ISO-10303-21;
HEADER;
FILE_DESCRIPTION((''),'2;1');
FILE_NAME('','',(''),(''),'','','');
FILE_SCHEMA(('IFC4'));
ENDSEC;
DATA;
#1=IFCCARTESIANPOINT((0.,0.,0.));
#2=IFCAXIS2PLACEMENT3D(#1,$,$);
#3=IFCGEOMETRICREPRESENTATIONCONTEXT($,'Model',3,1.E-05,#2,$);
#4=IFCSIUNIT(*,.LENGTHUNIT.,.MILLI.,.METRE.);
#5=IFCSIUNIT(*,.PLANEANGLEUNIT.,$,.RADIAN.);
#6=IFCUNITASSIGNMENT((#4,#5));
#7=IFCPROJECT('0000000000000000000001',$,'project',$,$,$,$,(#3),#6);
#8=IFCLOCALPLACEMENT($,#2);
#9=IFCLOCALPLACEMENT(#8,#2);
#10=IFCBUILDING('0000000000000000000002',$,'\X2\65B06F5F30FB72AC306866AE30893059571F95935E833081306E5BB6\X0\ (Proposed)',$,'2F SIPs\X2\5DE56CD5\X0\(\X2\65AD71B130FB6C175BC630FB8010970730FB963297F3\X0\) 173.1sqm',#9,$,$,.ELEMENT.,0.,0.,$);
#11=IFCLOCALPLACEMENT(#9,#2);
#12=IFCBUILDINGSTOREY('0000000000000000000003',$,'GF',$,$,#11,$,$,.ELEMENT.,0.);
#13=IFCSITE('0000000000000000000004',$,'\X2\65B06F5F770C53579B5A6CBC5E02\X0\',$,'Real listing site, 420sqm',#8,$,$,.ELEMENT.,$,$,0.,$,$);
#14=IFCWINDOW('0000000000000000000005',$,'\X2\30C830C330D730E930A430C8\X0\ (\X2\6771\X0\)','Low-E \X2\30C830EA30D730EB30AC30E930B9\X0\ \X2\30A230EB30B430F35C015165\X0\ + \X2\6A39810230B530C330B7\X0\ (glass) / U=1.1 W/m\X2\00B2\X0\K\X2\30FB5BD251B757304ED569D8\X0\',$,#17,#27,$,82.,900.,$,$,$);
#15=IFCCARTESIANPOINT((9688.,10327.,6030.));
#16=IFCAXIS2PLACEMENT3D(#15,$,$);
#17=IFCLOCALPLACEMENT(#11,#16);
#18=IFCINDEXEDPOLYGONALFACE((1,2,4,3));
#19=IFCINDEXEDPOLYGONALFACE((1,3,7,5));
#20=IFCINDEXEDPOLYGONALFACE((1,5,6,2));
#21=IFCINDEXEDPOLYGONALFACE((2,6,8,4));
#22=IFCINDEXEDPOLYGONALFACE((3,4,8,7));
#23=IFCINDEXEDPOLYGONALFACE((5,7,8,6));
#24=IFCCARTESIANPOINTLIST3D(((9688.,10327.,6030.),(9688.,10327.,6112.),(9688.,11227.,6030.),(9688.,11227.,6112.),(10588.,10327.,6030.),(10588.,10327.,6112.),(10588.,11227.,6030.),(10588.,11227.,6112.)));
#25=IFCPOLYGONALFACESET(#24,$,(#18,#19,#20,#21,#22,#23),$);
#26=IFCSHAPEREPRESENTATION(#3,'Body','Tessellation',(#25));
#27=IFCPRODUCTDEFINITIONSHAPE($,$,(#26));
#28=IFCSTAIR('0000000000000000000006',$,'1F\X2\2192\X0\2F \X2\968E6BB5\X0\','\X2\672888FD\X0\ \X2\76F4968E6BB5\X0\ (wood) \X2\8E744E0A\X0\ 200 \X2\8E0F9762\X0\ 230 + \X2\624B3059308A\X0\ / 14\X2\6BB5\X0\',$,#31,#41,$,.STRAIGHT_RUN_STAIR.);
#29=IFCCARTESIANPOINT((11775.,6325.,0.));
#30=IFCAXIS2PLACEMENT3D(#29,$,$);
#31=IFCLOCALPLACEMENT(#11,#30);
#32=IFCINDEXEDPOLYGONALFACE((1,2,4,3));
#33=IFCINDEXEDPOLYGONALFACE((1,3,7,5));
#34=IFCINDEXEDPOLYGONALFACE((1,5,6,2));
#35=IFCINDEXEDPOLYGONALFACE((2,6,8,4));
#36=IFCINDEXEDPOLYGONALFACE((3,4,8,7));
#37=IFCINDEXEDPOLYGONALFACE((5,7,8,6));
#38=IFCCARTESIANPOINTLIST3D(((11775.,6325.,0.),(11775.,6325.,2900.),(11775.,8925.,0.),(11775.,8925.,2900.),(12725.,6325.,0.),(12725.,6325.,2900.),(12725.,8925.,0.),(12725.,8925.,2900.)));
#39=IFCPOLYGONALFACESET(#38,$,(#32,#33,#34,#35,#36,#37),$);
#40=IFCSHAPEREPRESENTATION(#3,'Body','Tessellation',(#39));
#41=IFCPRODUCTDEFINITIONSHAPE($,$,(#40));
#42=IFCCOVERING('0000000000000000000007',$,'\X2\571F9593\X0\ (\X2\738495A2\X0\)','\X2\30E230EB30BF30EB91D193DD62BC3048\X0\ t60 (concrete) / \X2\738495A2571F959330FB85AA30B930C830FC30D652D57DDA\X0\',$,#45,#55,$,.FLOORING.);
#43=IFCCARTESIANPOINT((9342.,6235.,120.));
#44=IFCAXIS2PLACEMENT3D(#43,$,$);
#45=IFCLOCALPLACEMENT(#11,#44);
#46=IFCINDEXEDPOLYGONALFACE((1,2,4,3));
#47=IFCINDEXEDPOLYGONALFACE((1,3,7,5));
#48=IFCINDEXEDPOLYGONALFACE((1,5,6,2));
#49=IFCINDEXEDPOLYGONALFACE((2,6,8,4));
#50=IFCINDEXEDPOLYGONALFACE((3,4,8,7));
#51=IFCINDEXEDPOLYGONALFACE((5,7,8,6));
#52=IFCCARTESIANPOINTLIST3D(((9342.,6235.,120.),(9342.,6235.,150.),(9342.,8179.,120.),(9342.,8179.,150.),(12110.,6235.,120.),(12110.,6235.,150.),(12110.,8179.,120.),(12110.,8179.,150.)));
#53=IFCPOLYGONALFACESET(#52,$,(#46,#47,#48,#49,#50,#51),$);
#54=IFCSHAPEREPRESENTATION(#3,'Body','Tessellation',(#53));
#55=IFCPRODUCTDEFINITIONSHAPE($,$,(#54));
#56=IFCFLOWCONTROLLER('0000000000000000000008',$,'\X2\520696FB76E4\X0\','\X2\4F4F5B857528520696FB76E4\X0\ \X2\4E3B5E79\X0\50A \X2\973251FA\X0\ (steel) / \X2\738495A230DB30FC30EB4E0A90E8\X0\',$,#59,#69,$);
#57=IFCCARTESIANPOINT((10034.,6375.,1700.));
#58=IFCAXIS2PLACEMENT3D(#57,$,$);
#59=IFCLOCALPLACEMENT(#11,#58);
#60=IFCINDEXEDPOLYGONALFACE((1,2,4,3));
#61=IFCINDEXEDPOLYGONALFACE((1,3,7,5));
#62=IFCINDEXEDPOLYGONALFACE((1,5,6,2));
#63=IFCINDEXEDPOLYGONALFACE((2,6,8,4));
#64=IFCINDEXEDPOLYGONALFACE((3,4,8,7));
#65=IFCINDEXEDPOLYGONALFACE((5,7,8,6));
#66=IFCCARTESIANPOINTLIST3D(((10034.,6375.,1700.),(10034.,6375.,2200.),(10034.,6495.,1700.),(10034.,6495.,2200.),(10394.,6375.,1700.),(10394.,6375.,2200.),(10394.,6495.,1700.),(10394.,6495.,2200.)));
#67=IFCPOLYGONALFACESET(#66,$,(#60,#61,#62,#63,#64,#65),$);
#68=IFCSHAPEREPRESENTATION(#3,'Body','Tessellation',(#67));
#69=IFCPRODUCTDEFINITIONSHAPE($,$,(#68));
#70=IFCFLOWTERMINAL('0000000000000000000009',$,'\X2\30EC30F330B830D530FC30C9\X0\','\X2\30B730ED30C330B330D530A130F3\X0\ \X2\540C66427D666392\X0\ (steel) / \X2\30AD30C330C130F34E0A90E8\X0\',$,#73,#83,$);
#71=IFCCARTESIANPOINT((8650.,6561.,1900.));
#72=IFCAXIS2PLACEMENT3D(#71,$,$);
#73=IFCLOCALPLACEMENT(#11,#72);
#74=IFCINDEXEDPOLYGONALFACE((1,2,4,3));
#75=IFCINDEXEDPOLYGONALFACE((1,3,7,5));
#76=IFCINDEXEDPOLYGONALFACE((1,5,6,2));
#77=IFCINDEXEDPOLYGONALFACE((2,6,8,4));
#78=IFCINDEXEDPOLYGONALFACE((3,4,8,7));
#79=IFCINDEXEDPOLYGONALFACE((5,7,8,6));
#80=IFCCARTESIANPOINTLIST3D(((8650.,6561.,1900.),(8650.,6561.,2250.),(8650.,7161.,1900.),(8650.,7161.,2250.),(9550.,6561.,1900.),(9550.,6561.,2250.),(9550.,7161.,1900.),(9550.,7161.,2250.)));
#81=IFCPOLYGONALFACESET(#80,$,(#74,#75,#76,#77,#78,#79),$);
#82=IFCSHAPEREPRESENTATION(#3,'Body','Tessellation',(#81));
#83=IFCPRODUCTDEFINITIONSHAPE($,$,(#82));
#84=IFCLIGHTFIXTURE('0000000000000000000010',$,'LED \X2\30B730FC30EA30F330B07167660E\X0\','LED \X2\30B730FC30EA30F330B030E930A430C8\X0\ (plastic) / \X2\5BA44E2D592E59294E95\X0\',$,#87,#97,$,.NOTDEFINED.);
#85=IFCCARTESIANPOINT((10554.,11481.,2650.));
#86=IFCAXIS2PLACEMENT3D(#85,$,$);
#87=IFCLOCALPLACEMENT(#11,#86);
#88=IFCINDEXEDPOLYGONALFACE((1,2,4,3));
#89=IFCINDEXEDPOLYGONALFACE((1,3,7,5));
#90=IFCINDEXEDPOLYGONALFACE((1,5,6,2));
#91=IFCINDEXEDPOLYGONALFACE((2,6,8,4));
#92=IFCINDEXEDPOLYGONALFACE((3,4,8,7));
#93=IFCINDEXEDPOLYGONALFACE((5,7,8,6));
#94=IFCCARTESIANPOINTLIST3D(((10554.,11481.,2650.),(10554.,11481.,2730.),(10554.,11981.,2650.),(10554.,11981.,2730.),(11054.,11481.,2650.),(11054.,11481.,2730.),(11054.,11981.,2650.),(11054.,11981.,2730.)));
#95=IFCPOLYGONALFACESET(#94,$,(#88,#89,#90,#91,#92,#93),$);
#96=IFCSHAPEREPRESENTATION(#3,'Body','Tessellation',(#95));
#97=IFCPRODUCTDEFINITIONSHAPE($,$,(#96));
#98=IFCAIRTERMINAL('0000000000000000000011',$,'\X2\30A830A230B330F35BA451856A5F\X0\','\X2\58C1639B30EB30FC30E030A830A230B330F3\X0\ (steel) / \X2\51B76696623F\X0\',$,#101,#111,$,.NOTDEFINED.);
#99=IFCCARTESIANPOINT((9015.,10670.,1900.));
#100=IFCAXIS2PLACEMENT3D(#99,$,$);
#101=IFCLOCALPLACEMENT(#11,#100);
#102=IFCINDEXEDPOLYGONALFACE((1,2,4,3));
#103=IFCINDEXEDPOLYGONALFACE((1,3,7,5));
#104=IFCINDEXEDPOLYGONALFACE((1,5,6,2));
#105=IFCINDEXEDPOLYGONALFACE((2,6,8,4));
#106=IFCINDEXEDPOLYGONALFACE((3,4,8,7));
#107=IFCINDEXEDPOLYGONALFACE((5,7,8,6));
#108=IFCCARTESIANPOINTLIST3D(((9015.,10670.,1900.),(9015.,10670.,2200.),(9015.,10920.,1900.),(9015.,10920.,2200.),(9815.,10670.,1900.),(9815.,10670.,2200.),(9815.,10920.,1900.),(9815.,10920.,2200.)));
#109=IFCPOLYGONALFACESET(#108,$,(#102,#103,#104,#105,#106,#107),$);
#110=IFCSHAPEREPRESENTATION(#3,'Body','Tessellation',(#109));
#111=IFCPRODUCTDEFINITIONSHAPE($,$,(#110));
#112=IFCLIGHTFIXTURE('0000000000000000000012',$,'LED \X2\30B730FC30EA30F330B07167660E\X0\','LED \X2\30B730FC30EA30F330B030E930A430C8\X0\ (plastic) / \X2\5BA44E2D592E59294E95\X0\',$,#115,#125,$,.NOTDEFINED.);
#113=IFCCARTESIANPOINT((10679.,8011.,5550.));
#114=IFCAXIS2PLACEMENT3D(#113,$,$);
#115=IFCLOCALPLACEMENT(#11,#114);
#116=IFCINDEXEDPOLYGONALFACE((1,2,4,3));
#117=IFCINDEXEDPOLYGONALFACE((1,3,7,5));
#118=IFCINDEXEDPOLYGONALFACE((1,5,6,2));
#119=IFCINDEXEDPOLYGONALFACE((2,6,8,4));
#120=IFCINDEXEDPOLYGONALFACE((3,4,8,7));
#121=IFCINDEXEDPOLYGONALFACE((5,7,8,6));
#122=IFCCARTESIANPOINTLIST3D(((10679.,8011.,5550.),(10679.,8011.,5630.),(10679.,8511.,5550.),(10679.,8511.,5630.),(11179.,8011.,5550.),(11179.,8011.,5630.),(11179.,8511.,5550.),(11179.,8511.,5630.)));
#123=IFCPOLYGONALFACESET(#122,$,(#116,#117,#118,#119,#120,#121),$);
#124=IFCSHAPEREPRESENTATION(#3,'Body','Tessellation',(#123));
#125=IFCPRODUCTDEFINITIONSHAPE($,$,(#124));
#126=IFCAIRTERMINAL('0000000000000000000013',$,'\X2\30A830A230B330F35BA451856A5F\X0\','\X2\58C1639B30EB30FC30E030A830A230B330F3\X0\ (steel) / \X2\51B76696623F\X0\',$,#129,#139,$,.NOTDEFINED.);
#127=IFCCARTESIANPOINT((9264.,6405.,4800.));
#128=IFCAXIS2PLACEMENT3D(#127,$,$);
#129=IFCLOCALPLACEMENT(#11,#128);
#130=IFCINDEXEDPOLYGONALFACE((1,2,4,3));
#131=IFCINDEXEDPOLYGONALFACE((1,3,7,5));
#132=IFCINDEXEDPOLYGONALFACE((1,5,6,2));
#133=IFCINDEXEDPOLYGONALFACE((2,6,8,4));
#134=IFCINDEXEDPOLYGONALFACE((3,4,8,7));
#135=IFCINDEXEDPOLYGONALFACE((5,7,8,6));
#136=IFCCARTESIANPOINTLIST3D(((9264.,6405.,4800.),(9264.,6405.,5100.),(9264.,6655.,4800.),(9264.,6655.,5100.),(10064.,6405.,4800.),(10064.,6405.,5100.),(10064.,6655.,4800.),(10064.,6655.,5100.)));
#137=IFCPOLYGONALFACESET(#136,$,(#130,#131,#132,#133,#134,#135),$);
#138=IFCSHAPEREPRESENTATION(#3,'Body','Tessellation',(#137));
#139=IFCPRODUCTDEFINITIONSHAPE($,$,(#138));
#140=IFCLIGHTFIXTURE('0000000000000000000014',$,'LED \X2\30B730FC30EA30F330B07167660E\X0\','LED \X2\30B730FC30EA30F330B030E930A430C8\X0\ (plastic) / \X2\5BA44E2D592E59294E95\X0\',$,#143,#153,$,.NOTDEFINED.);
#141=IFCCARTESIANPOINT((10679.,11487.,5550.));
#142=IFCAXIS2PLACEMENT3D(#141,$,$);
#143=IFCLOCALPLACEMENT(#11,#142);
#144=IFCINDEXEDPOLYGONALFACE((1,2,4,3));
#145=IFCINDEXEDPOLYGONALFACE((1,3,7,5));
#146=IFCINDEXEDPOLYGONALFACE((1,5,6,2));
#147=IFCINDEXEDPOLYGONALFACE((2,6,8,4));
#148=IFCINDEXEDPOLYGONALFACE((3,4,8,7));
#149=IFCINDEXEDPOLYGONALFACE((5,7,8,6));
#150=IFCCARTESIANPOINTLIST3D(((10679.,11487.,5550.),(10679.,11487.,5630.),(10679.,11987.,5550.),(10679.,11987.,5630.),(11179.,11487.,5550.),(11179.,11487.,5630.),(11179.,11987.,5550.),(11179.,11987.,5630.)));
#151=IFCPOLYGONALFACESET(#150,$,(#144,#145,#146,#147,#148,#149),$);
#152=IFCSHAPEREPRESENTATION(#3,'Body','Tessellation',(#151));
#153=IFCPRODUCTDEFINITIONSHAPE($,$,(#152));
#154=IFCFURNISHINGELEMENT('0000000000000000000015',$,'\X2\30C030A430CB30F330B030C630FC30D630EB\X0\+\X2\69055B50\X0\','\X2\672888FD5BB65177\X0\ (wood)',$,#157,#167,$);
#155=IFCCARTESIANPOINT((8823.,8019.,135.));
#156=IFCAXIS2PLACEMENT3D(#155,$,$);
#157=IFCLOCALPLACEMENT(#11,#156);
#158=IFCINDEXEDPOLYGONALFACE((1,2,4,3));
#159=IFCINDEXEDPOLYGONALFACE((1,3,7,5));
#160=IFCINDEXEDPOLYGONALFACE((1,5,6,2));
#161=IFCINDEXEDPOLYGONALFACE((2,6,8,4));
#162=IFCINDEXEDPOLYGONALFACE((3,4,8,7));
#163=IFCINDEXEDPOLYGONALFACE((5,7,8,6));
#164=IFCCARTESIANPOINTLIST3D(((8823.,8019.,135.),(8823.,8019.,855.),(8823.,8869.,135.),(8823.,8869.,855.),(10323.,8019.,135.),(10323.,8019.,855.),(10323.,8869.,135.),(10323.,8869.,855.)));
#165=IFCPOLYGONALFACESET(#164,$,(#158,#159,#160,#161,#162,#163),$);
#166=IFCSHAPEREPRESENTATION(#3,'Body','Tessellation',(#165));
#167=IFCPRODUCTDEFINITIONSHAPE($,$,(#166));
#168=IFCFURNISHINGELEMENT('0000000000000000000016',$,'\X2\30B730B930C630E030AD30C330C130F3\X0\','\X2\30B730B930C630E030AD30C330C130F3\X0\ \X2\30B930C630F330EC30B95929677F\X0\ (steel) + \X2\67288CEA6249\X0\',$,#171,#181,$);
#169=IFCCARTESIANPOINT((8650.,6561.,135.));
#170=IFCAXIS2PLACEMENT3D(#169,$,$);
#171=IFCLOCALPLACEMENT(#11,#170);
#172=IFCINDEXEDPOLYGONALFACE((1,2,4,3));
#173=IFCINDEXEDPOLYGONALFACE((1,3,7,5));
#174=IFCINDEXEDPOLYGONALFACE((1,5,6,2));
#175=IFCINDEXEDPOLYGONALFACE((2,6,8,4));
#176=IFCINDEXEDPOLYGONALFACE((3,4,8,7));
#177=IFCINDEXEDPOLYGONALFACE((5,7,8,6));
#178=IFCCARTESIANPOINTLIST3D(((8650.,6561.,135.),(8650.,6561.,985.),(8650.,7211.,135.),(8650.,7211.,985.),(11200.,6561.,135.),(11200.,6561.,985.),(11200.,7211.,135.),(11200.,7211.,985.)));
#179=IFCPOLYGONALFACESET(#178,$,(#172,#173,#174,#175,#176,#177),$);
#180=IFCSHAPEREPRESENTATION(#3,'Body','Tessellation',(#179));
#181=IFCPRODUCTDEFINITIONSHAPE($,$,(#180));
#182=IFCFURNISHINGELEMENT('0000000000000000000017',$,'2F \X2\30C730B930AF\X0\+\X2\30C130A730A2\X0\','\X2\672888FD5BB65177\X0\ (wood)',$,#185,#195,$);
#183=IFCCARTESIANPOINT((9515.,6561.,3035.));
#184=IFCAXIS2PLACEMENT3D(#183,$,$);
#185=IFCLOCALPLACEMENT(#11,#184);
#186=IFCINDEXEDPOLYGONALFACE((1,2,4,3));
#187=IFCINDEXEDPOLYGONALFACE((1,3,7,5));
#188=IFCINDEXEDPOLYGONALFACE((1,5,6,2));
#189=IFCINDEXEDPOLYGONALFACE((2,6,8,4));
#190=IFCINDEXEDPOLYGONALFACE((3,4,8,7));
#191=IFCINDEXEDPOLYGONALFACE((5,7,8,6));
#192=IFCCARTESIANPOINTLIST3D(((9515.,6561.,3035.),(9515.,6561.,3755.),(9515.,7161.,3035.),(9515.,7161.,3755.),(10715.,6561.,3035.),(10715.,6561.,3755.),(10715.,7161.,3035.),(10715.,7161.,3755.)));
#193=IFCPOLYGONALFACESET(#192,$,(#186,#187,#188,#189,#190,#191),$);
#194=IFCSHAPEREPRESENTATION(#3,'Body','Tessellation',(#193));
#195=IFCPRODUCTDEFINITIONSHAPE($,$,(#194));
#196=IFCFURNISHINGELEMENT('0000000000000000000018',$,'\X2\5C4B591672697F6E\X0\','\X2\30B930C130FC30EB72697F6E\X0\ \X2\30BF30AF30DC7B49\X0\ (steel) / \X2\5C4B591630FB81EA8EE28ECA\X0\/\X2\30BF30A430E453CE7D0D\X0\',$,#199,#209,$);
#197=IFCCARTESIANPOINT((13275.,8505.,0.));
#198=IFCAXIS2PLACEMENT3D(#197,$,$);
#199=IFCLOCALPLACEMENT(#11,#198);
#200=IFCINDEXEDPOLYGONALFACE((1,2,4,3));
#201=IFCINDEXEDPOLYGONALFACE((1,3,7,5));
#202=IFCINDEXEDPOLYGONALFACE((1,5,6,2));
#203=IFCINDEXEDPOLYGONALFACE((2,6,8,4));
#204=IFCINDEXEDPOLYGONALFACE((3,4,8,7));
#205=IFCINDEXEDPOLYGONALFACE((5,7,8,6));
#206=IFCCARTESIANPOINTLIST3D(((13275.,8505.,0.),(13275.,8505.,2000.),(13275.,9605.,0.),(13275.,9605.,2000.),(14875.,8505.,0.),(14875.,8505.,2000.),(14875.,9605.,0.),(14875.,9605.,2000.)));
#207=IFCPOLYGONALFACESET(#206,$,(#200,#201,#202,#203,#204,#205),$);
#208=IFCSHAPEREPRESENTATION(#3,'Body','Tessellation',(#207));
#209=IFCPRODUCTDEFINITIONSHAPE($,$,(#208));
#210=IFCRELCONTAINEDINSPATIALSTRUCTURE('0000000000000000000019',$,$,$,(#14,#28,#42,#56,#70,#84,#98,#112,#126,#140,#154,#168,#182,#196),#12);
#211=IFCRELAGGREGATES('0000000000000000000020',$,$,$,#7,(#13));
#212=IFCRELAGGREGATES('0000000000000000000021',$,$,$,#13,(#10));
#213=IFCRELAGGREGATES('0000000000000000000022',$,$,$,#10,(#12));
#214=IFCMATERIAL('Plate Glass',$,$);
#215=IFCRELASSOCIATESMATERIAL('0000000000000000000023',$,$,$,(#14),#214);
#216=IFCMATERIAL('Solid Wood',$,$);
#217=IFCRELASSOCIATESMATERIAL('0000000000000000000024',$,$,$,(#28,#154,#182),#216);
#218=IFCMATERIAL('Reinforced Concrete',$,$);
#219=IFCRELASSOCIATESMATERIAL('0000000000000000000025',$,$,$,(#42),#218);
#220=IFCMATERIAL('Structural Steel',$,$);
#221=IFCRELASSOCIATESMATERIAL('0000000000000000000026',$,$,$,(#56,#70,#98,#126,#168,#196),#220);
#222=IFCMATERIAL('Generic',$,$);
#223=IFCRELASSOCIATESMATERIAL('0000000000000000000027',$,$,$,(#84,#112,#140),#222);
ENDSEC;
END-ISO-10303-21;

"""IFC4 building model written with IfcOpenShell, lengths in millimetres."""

from ifc_helpers import new_model, si_unit, frame, frame_2d, origin, place, context, project, spatial, rectangle, extrude, material, element, save


model = new_model("IFC4")

# Units and contexts
model_context = context("Model", 3, precision=1e-05, world=origin())
ifc_project = project(units=[si_unit("LENGTHUNIT", "METRE", prefix="MILLI"), si_unit("PLANEANGLEUNIT", "RADIAN")], contexts=[model_context])

# Site, building, storey
site_placement = place(None, origin())
site = spatial("IfcSite", under=ifc_project, at=site_placement, Name="新潟県南魚沼市", ObjectType="Real listing site, 420sqm", CompositionType="ELEMENT", RefElevation=0.0)
building_placement = place(site_placement, origin())
building = spatial("IfcBuilding", under=site, at=building_placement, Name="新潟・犬と暮らす土間広めの家 (Proposed)", ObjectType="2F SIPs工法(断熱・気密・耐震・防音) 173.1sqm", CompositionType="ELEMENT", ElevationOfRefHeight=0.0, ElevationOfTerrain=0.0)
storey_placement = place(building_placement, origin())
storey = spatial("IfcBuildingStorey", under=building, at=storey_placement, Name="GF", CompositionType="ELEMENT", Elevation=0.0)

# Shared definitions
ifc_material_1 = material(Name="Solid Wood")

# Window
ifc_material_2 = material(Name="Plate Glass")
window_placement = place(storey_placement, frame((9688.0, 10327.0, 6030.0)))
element("IfcWindow", 1, at=window_placement, inside=storey, material=ifc_material_2, Name="トップライト (東)", Description="Low-E トリプルガラス アルゴン封入 + 樹脂サッシ (glass) / U=1.1 W/m²K・寒冷地仕様", OverallHeight=82.0, OverallWidth=900.0, context=model_context, shape_type="SweptSolid", body=[
    extrude(rectangle(XDim=900.0, YDim=900.0, at=frame_2d((450.0, 450.0))), frame((9688.0, 10327.0, 6030.0)), (0.0, 0.0, 1.0), 82.0),
])

# Stair
stair_placement = place(storey_placement, frame((11775.0, 6325.0, 0.0)))
element("IfcStair", 2, at=stair_placement, inside=storey, material=ifc_material_1, Name="1F→2F 階段", Description="木製 直階段 (wood) 蹴上 200 踏面 230 + 手すり / 14段", PredefinedType="STRAIGHT_RUN_STAIR", context=model_context, shape_type="SweptSolid", body=[
    extrude(rectangle(XDim=950.0, YDim=2600.0, at=frame_2d((475.0, 1300.0))), frame((11775.0, 6325.0, 0.0)), (0.0, 0.0, 1.0), 2900.0),
])

# Covering
ifc_material_3 = material(Name="Reinforced Concrete")
covering_placement = place(storey_placement, frame((9342.0, 6235.0, 120.0)))
element("IfcCovering", 3, at=covering_placement, inside=storey, material=ifc_material_3, Name="土間 (玄関)", Description="モルタル金鏝押え t60 (concrete) / 玄関土間・薪ストーブ動線", PredefinedType="FLOORING", context=model_context, shape_type="SweptSolid", body=[
    extrude(rectangle(XDim=2768.0, YDim=1944.0, at=frame_2d((1384.0, 972.0))), frame((9342.0, 6235.0, 120.0)), (0.0, 0.0, 1.0), 30.0),
])

# Flow controller
ifc_material_4 = material(Name="Structural Steel")
flow_controller_placement = place(storey_placement, frame((10034.0, 6375.0, 1700.0)))
element("IfcFlowController", 4, at=flow_controller_placement, inside=storey, material=ifc_material_4, Name="分電盤", Description="住宅用分電盤 主幹50A 露出 (steel) / 玄関ホール上部", context=model_context, shape_type="SweptSolid", body=[
    extrude(rectangle(XDim=360.0, YDim=120.0, at=frame_2d((180.0, 60.0))), frame((10034.0, 6375.0, 1700.0)), (0.0, 0.0, 1.0), 500.0),
])

# Flow terminal
flow_terminal_placement = place(storey_placement, frame((8650.0, 6561.0, 1900.0)))
element("IfcFlowTerminal", 5, at=flow_terminal_placement, inside=storey, material=ifc_material_4, Name="レンジフード", Description="シロッコファン 同時給排 (steel) / キッチン上部", context=model_context, shape_type="SweptSolid", body=[
    extrude(rectangle(XDim=900.0, YDim=600.0, at=frame_2d((450.0, 300.0))), frame((8650.0, 6561.0, 1900.0)), (0.0, 0.0, 1.0), 350.0),
])

# Light fixture
ifc_material_5 = material(Name="Generic")
light_fixture_1_placement = place(storey_placement, frame((10554.0, 11481.0, 2650.0)))
element("IfcLightFixture", 6, at=light_fixture_1_placement, inside=storey, material=ifc_material_5, Name="LED シーリング照明", Description="LED シーリングライト (plastic) / 室中央天井", PredefinedType="NOTDEFINED", context=model_context, shape_type="SweptSolid", body=[
    extrude(rectangle(XDim=500.0, YDim=500.0, at=frame_2d((250.0, 250.0))), frame((10554.0, 11481.0, 2650.0)), (0.0, 0.0, 1.0), 80.0),
])

# Air terminal
air_terminal_1_placement = place(storey_placement, frame((9015.0, 10670.0, 1900.0)))
element("IfcAirTerminal", 7, at=air_terminal_1_placement, inside=storey, material=ifc_material_4, Name="エアコン室内機", Description="壁掛ルームエアコン (steel) / 冷暖房", PredefinedType="NOTDEFINED", context=model_context, shape_type="SweptSolid", body=[
    extrude(rectangle(XDim=800.0, YDim=250.0, at=frame_2d((400.0, 125.0))), frame((9015.0, 10670.0, 1900.0)), (0.0, 0.0, 1.0), 300.0),
])

# Light fixture
light_fixture_2_placement = place(storey_placement, frame((10679.0, 8011.0, 5550.0)))
element("IfcLightFixture", 8, at=light_fixture_2_placement, inside=storey, material=ifc_material_5, Name="LED シーリング照明", Description="LED シーリングライト (plastic) / 室中央天井", PredefinedType="NOTDEFINED", context=model_context, shape_type="SweptSolid", body=[
    extrude(rectangle(XDim=500.0, YDim=500.0, at=frame_2d((250.0, 250.0))), frame((10679.0, 8011.0, 5550.0)), (0.0, 0.0, 1.0), 80.0),
])

# Air terminal
air_terminal_2_placement = place(storey_placement, frame((9264.0, 6405.0, 4800.0)))
element("IfcAirTerminal", 9, at=air_terminal_2_placement, inside=storey, material=ifc_material_4, Name="エアコン室内機", Description="壁掛ルームエアコン (steel) / 冷暖房", PredefinedType="NOTDEFINED", context=model_context, shape_type="SweptSolid", body=[
    extrude(rectangle(XDim=800.0, YDim=250.0, at=frame_2d((400.0, 125.0))), frame((9264.0, 6405.0, 4800.0)), (0.0, 0.0, 1.0), 300.0),
])

# Light fixture
light_fixture_3_placement = place(storey_placement, frame((10679.0, 11487.0, 5550.0)))
element("IfcLightFixture", 10, at=light_fixture_3_placement, inside=storey, material=ifc_material_5, Name="LED シーリング照明", Description="LED シーリングライト (plastic) / 室中央天井", PredefinedType="NOTDEFINED", context=model_context, shape_type="SweptSolid", body=[
    extrude(rectangle(XDim=500.0, YDim=500.0, at=frame_2d((250.0, 250.0))), frame((10679.0, 11487.0, 5550.0)), (0.0, 0.0, 1.0), 80.0),
])

# Furnishing elements
furnishing_1_placement = place(storey_placement, frame((8823.0, 8019.0, 135.0)))
element("IfcFurnishingElement", 11, at=furnishing_1_placement, inside=storey, material=ifc_material_1, Name="ダイニングテーブル+椅子", Description="木製家具 (wood)", context=model_context, shape_type="SweptSolid", body=[
    extrude(rectangle(XDim=1500.0, YDim=850.0, at=frame_2d((750.0, 425.0))), frame((8823.0, 8019.0, 135.0)), (0.0, 0.0, 1.0), 720.0),
])
furnishing_2_placement = place(storey_placement, frame((8650.0, 6561.0, 135.0)))
element("IfcFurnishingElement", 12, at=furnishing_2_placement, inside=storey, material=ifc_material_4, Name="システムキッチン", Description="システムキッチン ステンレス天板 (steel) + 木質扉", context=model_context, shape_type="SweptSolid", body=[
    extrude(rectangle(XDim=2550.0, YDim=650.0, at=frame_2d((1275.0, 325.0))), frame((8650.0, 6561.0, 135.0)), (0.0, 0.0, 1.0), 850.0),
])
furnishing_3_placement = place(storey_placement, frame((9515.0, 6561.0, 3035.0)))
element("IfcFurnishingElement", 13, at=furnishing_3_placement, inside=storey, material=ifc_material_1, Name="2F デスク+チェア", Description="木製家具 (wood)", context=model_context, shape_type="SweptSolid", body=[
    extrude(rectangle(XDim=1200.0, YDim=600.0, at=frame_2d((600.0, 300.0))), frame((9515.0, 6561.0, 3035.0)), (0.0, 0.0, 1.0), 720.0),
])
furnishing_4_placement = place(storey_placement, frame((13275.0, 8505.0, 0.0)))
element("IfcFurnishingElement", 14, at=furnishing_4_placement, inside=storey, material=ifc_material_4, Name="屋外物置", Description="スチール物置 タクボ等 (steel) / 屋外・自転車/タイヤ収納", context=model_context, shape_type="SweptSolid", body=[
    extrude(rectangle(XDim=1600.0, YDim=1100.0, at=frame_2d((800.0, 550.0))), frame((13275.0, 8505.0, 0.0)), (0.0, 0.0, 1.0), 2000.0),
])

save(model, "model.ifc")
